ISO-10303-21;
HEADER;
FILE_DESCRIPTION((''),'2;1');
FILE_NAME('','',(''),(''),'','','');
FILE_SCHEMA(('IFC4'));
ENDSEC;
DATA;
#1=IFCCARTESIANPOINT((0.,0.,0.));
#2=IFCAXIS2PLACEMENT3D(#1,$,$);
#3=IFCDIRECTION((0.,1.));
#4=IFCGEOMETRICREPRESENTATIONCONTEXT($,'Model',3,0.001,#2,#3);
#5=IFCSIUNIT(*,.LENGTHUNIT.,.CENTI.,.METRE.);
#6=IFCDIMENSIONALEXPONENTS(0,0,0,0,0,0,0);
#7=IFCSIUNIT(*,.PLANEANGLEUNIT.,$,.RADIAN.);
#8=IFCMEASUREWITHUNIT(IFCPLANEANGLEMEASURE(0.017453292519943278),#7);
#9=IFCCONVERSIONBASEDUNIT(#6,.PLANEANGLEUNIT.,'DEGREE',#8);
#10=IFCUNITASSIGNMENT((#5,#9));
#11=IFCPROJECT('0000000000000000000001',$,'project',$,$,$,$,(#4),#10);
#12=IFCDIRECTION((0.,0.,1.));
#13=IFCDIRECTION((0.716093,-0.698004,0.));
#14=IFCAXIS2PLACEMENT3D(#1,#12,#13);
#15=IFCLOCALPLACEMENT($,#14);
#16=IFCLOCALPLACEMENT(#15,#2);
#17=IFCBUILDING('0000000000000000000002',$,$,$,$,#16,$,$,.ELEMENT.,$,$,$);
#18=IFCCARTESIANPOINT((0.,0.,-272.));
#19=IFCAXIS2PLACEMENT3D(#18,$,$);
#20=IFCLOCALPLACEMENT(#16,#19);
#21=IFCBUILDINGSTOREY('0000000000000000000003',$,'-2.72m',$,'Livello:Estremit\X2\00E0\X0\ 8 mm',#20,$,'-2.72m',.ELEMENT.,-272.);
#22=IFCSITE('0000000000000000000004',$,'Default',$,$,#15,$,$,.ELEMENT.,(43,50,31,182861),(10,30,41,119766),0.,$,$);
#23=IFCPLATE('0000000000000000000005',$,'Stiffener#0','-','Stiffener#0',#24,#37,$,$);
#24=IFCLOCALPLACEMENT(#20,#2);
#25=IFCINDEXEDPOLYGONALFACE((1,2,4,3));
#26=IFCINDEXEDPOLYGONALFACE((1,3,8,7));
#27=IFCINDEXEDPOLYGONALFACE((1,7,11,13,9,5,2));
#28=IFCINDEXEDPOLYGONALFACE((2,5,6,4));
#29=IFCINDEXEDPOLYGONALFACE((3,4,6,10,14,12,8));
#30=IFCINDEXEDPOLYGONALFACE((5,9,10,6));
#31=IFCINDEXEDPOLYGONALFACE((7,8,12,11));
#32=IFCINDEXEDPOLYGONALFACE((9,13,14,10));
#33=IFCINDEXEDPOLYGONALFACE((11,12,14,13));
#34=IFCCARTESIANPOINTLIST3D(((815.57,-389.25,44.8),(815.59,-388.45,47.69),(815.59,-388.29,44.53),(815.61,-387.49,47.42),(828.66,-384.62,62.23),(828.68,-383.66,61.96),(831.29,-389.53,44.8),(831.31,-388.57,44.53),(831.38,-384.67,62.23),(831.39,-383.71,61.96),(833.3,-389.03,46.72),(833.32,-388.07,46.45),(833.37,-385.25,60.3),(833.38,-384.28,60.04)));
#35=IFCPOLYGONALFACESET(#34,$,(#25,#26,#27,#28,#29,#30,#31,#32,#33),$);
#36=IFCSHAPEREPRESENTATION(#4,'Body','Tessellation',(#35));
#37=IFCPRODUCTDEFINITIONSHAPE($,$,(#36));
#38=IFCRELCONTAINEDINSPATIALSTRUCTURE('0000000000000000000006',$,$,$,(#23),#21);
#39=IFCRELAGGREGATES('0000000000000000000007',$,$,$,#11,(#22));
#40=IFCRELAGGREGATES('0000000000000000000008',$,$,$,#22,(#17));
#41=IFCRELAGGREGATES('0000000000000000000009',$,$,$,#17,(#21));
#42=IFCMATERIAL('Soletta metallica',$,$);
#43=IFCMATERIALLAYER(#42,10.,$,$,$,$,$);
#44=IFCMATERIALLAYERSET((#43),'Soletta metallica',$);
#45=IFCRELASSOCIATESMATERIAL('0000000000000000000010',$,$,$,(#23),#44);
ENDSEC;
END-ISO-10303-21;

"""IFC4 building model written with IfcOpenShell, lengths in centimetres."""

from ifc_helpers import new_model, entity, si_unit, converted_unit, direction, frame, origin, origin_with_axes, place, context, project, spatial, polyline, outline, extrude, material, layer, layer_set, element, save


model = new_model("IFC4")

# Units and contexts
model_context = context("Model", 3, precision=0.001, world=origin(), true_north=direction((0.0, 1.0)))
ifc_project = project(units=[si_unit("LENGTHUNIT", "METRE", prefix="CENTI"), converted_unit("PLANEANGLEUNIT", "DEGREE", entity("IfcPlaneAngleMeasure", 0.017453292519943278), si_unit("PLANEANGLEUNIT", "RADIAN"), dimensions=[0, 0, 0, 0, 0, 0, 0])], contexts=[model_context])

# Site, building, storey
site_placement = place(None, frame((0.0, 0.0, 0.0), z_axis=(0.0, 0.0, 1.0), x_axis=(0.716093, -0.698004, 0.0)))
site = spatial("IfcSite", under=ifc_project, at=site_placement, Name="Default", CompositionType="ELEMENT", RefLatitude=(43, 50, 31, 182861), RefLongitude=(10, 30, 41, 119766), RefElevation=0.0)
building_placement = place(site_placement, origin())
building = spatial("IfcBuilding", under=site, at=building_placement, CompositionType="ELEMENT")
storey_placement = place(building_placement, frame((0.0, 0.0, -272.0)))
storey = spatial("IfcBuildingStorey", under=building, at=storey_placement, Name="-2.72m", ObjectType="Livello:Estremità 8 mm", LongName="-2.72m", CompositionType="ELEMENT", Elevation=-272.0)

# Shared definitions
ifc_material = material(Name="Soletta metallica")

# Shared definitions
ifc_layer_1 = layer(ifc_material, 10.0)
ifc_layer_set_1 = layer_set([ifc_layer_1], Name="Soletta metallica")

# Plate
plate_1_placement = place(storey_placement, frame((833.39, -383.74, 61.96), z_axis=(-0.0171, -0.963097, 0.268612), x_axis=(-0.999842, 0.017752, 0.0)))
element("IfcPlate", 1, at=plate_1_placement, inside=storey, material=ifc_layer_set_1, Name="Stiffener#0", Description="-", ObjectType="Stiffener#0", context=model_context, shape_type="SweptSolid", body=[
    extrude(outline(polyline([(0.0, 2.0), (2.0, 0.0), (4.72, 0.0), (17.72, 15.1), (17.72, 18.1), (2.0, 18.1), (0.0, 16.1), (0.0, 2.0)])), origin_with_axes(), (0.0, 0.0, 1.0), 1.0),
])

save(model, "model.ifc")
